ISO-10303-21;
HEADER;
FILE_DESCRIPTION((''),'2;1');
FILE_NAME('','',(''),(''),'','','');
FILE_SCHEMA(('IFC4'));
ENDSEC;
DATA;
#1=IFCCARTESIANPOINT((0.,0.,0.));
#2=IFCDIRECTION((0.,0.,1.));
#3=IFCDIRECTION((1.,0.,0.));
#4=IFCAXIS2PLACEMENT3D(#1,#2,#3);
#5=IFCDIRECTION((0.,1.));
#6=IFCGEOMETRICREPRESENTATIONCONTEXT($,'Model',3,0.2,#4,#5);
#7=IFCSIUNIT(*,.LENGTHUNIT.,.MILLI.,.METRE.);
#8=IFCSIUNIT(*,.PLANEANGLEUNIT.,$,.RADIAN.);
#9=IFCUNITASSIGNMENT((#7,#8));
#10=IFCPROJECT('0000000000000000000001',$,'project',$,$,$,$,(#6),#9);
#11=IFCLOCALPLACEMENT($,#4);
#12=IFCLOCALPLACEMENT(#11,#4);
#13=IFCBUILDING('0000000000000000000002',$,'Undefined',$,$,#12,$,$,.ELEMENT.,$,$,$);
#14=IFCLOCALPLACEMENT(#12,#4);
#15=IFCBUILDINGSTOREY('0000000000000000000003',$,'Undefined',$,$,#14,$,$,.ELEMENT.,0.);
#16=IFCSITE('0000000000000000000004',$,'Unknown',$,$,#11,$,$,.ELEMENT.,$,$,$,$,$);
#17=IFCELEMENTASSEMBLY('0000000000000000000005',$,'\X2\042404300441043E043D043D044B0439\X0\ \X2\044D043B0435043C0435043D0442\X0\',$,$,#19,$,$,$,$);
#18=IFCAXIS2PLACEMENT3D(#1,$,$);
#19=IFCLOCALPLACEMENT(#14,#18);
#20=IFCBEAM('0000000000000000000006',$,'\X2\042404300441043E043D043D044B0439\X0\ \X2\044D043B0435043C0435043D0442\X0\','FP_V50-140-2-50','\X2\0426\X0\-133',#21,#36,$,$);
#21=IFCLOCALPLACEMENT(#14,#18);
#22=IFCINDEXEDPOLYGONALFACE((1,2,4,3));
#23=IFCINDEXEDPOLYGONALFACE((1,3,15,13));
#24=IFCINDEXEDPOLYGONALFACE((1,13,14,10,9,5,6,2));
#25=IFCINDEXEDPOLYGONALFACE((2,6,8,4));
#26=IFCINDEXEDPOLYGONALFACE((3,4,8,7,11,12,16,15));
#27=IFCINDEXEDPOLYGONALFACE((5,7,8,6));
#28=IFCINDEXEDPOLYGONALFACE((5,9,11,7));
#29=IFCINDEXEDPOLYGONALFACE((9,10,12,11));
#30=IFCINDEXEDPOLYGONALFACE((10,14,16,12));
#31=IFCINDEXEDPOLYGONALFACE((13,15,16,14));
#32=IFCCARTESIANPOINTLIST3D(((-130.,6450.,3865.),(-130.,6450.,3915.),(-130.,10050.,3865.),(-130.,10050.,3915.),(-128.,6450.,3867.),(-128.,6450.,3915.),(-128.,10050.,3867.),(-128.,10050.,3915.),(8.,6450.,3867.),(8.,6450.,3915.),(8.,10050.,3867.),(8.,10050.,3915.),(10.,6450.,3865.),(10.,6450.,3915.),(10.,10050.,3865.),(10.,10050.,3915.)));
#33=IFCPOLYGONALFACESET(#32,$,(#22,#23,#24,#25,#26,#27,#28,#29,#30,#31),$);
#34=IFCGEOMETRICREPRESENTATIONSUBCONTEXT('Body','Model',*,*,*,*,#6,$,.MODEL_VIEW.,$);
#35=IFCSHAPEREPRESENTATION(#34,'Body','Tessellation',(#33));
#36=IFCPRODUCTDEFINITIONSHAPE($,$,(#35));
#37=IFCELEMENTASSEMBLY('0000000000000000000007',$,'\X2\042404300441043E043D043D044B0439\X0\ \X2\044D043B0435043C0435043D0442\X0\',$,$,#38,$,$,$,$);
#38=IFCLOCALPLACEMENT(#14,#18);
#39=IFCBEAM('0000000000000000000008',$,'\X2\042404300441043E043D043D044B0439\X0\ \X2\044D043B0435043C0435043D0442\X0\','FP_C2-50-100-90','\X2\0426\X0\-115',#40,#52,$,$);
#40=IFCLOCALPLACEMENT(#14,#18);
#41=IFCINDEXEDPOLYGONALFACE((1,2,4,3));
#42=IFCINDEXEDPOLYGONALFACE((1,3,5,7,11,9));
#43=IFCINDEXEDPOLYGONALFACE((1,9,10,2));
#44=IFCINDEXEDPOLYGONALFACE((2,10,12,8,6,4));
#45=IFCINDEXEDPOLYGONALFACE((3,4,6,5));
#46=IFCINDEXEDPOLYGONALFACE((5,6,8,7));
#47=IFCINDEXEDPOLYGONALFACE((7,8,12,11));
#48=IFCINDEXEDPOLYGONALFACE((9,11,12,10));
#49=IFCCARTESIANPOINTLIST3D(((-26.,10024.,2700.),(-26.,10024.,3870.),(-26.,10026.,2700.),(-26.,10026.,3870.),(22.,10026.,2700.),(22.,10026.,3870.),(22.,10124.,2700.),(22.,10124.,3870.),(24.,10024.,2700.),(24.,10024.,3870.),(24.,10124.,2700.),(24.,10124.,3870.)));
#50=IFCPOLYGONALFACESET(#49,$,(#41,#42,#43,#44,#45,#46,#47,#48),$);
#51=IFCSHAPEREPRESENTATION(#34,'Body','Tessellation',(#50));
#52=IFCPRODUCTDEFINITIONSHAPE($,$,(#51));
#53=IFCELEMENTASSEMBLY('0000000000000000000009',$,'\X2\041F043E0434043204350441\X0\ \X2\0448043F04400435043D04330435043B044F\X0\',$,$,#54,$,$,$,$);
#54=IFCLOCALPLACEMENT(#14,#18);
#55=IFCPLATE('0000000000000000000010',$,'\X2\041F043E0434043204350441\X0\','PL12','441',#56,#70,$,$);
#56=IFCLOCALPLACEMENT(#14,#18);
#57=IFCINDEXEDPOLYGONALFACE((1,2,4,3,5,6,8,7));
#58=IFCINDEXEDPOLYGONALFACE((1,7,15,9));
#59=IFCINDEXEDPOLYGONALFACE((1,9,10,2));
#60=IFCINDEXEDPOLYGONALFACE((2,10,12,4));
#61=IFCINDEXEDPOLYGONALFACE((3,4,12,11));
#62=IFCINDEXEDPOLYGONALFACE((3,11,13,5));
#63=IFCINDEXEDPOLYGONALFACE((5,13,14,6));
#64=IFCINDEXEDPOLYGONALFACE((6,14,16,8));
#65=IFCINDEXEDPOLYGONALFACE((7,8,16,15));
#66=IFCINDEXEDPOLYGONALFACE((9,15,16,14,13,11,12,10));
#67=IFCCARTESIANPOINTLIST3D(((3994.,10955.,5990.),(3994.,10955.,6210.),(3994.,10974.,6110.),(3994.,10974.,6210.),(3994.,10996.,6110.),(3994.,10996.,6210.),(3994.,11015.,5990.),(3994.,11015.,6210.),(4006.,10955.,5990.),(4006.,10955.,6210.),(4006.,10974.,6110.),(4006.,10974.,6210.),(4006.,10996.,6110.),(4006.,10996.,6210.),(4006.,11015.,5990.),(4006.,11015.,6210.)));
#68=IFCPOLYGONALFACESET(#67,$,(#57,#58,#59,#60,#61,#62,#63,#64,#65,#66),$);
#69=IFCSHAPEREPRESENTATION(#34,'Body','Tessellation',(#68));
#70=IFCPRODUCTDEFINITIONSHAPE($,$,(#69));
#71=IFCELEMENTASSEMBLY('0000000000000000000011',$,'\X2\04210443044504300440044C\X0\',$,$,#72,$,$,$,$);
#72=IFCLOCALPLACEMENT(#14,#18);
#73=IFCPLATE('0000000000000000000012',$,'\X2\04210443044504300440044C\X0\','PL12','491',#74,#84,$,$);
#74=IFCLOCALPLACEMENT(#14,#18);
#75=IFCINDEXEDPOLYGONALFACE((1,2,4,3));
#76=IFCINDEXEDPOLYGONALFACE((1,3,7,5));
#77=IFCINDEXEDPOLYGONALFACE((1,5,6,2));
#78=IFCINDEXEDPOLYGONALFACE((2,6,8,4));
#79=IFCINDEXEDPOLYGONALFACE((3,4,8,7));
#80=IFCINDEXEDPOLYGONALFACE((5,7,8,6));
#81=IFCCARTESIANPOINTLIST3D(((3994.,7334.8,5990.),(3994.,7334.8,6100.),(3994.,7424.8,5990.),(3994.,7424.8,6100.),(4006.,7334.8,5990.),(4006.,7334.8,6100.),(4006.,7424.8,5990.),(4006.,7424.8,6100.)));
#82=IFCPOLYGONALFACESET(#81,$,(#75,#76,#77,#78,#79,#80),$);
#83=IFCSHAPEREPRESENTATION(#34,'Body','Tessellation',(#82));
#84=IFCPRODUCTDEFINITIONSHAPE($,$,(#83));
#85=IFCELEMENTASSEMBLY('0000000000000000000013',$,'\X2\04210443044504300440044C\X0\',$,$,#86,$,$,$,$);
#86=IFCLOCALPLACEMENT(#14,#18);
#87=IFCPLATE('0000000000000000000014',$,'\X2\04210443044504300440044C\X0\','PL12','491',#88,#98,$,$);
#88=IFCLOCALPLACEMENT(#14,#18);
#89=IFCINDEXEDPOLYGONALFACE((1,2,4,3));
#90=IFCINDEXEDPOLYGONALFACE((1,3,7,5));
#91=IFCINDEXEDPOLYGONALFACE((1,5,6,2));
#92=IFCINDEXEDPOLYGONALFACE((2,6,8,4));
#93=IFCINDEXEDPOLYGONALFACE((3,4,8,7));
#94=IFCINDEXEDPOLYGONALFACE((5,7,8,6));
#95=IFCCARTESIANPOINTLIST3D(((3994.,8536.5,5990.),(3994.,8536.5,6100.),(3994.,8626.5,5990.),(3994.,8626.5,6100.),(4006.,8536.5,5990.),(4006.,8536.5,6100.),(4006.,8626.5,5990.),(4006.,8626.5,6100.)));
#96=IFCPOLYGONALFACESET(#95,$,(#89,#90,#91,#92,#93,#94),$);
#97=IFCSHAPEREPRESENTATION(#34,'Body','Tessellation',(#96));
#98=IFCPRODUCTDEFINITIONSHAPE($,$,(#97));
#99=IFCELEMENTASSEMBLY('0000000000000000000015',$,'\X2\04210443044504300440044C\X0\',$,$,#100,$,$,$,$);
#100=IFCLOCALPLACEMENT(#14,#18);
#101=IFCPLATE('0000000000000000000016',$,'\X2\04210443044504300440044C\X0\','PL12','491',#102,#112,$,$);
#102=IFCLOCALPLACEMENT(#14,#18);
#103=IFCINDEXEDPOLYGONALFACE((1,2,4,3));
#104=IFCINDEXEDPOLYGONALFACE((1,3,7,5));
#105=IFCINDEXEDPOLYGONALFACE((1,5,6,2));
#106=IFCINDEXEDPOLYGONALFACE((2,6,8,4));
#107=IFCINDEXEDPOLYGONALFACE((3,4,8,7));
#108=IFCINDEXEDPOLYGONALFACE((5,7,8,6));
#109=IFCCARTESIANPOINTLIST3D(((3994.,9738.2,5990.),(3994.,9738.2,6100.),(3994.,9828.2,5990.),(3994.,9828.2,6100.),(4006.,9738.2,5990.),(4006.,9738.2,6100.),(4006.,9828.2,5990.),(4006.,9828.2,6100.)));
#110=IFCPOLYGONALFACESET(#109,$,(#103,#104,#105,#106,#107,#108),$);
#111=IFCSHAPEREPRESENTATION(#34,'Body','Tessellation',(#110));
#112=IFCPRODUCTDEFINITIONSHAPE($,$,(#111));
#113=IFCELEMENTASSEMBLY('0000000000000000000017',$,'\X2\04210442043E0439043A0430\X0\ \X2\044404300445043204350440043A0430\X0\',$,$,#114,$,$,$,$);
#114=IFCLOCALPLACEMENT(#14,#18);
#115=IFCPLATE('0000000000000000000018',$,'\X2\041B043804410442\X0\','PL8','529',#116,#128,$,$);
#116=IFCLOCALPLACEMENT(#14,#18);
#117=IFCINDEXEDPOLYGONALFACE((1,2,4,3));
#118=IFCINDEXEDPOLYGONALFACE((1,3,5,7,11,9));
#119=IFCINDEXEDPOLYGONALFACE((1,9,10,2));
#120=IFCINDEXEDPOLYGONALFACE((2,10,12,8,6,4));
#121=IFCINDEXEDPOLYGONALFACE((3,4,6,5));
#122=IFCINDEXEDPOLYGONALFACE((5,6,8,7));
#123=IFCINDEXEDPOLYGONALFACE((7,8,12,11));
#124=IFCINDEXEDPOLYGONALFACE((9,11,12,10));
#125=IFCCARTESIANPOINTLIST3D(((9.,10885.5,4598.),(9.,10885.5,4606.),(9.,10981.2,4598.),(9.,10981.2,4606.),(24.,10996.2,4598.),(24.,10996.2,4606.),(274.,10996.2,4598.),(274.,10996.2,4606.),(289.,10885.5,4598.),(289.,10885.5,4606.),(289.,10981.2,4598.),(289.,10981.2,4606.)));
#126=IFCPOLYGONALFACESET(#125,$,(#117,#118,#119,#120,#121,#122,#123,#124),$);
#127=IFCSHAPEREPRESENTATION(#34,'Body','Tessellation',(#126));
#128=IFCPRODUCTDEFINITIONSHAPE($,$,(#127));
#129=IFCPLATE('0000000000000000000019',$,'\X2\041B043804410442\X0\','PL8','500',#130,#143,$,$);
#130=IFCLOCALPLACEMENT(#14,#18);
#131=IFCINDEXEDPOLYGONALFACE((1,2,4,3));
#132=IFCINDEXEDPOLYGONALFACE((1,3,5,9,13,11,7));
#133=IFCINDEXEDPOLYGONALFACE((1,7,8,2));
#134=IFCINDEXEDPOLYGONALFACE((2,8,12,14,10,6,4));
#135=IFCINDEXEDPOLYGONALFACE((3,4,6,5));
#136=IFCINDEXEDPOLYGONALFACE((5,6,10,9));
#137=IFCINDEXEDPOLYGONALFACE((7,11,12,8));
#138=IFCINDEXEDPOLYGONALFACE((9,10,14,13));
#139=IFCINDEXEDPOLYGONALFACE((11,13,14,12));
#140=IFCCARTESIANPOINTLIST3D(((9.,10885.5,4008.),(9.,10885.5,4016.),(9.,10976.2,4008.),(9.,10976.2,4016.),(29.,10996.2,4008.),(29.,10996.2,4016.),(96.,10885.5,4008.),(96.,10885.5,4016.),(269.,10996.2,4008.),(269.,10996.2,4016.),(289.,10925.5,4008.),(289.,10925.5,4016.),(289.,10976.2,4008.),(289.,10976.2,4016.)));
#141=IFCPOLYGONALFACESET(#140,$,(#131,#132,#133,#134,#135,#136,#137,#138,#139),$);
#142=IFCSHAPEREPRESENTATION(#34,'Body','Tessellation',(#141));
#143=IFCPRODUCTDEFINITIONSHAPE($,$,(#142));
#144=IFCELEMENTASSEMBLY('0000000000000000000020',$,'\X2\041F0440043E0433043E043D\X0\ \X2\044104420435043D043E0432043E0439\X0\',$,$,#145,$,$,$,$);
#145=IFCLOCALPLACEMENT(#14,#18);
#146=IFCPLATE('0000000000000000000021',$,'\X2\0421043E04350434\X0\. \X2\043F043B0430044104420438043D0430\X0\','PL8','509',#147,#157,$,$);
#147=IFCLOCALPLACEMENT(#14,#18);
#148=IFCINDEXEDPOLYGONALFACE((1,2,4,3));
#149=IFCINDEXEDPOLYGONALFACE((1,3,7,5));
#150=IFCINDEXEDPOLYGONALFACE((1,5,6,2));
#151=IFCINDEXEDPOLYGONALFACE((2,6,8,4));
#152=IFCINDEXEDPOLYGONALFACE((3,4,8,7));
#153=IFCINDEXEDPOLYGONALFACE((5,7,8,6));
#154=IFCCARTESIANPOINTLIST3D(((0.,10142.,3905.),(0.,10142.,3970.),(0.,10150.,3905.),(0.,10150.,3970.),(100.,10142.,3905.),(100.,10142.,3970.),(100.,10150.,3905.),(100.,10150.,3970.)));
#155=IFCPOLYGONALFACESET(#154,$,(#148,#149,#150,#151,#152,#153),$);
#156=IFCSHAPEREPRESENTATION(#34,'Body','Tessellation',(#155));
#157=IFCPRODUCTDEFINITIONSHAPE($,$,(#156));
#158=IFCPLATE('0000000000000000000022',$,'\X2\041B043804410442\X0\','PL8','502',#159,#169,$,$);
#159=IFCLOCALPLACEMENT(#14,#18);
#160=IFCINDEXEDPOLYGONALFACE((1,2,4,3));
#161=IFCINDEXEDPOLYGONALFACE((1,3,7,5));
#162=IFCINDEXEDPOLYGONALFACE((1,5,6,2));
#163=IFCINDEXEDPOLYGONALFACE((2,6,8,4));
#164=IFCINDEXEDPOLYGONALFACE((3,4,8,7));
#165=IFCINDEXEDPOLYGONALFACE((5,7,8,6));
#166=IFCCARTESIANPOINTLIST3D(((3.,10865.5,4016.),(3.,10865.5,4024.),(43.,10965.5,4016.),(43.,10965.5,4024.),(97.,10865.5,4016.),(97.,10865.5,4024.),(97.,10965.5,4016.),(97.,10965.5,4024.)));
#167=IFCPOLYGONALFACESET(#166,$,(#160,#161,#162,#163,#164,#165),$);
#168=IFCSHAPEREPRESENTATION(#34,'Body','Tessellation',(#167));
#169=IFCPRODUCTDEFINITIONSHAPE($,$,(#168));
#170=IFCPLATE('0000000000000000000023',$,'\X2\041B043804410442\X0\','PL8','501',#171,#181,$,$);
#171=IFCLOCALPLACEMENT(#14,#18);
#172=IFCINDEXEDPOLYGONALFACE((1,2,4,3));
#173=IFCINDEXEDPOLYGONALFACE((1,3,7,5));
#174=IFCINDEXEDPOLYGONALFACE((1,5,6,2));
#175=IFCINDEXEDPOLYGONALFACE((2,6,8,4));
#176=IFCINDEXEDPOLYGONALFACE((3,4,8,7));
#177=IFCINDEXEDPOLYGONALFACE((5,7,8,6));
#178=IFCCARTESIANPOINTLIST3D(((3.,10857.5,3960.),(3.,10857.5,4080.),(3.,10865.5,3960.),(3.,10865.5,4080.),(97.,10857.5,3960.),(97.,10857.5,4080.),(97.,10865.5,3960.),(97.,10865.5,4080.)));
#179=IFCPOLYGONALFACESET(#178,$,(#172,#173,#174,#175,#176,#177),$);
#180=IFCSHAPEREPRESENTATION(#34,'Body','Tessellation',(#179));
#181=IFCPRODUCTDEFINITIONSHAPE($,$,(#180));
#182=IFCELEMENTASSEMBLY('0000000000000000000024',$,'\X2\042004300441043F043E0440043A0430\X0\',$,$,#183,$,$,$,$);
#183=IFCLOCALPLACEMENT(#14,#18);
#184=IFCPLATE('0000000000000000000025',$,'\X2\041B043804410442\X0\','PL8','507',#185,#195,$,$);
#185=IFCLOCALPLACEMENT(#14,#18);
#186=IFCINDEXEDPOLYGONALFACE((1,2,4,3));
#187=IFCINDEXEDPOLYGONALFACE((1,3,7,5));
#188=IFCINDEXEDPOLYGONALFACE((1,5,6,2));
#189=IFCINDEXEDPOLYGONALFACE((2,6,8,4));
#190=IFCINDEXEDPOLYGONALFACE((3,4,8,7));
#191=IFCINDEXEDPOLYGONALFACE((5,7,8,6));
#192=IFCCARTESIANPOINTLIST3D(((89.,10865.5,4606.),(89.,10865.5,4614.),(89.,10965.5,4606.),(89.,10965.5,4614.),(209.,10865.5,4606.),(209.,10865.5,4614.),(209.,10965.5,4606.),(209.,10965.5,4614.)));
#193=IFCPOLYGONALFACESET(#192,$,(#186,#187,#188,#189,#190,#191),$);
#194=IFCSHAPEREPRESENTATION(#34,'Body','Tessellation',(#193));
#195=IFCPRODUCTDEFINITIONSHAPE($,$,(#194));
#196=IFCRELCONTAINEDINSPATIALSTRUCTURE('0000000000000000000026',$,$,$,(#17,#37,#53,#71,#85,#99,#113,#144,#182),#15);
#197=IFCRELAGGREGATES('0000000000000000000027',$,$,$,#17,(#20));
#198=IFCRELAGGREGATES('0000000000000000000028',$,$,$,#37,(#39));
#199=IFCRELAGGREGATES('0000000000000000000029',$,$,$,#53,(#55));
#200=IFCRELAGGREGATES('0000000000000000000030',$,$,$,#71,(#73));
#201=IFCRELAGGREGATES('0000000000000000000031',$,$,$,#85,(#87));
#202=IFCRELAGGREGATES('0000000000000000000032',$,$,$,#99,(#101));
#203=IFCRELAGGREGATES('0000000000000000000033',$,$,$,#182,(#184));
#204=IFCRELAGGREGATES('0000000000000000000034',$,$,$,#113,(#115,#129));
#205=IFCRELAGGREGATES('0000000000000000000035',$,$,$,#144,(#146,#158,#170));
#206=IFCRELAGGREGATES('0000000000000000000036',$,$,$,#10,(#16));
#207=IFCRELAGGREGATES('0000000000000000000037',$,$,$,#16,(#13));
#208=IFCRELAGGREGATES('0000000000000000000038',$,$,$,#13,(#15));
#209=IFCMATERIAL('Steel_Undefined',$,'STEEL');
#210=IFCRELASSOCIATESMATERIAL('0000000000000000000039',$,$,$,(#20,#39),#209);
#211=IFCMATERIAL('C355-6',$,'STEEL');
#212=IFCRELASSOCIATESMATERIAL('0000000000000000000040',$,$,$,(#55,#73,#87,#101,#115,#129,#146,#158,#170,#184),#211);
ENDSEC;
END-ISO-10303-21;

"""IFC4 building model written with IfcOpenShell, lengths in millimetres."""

from ifc_helpers import new_model, si_unit, direction, frame, origin_with_axes, place, context, subcontext, project, spatial, line, indexed_curve, outline, extrude, material, element, aggregate, save


model = new_model("IFC4")

# Units and contexts
model_context = context("Model", 3, precision=0.2, world=origin_with_axes(), true_north=direction((0.0, 1.0)))
body_context = subcontext(model_context, "Body", "Model", "MODEL_VIEW")
ifc_project = project(units=[si_unit("LENGTHUNIT", "METRE", prefix="MILLI"), si_unit("PLANEANGLEUNIT", "RADIAN")], contexts=[model_context])

# Site, building, storey
site_placement = place(None, origin_with_axes())
site = spatial("IfcSite", under=ifc_project, at=site_placement, Name="Unknown", CompositionType="ELEMENT")
building_placement = place(site_placement, origin_with_axes())
building = spatial("IfcBuilding", under=site, at=building_placement, Name="Undefined", CompositionType="ELEMENT")
storey_placement = place(building_placement, origin_with_axes())
storey = spatial("IfcBuildingStorey", under=building, at=storey_placement, Name="Undefined", CompositionType="ELEMENT", Elevation=0.0)

# Element assemblies, beams
assembly_1_placement = place(storey_placement, frame((-60.0, 10050.0, 3890.0), z_axis=(1.0, 0.0, 0.0), x_axis=(0.0, -1.0, 0.0)))
assembly_1 = element("IfcElementAssembly", 1, at=assembly_1_placement, inside=storey, Name="Фасонный элемент")
ifc_material_1 = material(Name="Steel_Undefined", Category="STEEL")
beam_1_placement = place(assembly_1_placement, origin_with_axes())
beam_1 = element("IfcBeam", 2, at=beam_1_placement, material=ifc_material_1, Name="Фасонный элемент", Description="FP_V50-140-2-50", ObjectType="Ц-133", context=body_context, shape_type="SolidModel", body=[
    extrude(outline(indexed_curve([(-70.0, -25.0), (-68.0, -25.0), (-68.0, 23.0), (68.0, 23.0), (68.0, -25.0), (70.0, -25.0), (70.0, 25.0), (-70.0, 25.0)], segments=[line(1, 2, 3, 4, 5, 6, 7, 8, 1)])), frame((0.0, 0.0, 0.0), z_axis=(-1.0, 0.0, 0.0), x_axis=(0.0, 0.0, 1.0)), (0.0, 0.0, -1.0), 3600.0),
])
aggregate(assembly_1, [beam_1])
assembly_2_placement = place(storey_placement, frame((-1.0, 10025.0, 3870.0), z_axis=(1.0, 0.0, 0.0), x_axis=(0.0, 0.0, -1.0)))
assembly_2 = element("IfcElementAssembly", 3, at=assembly_2_placement, inside=storey, Name="Фасонный элемент")
beam_2_placement = place(assembly_2_placement, origin_with_axes())
beam_2 = element("IfcBeam", 4, at=beam_2_placement, material=ifc_material_1, Name="Фасонный элемент", Description="FP_C2-50-100-90", ObjectType="Ц-115", context=body_context, shape_type="SolidModel", body=[
    extrude(outline(indexed_curve([(-25.0, -1.0), (25.0, -1.0), (25.0, 99.0), (23.0, 99.0), (23.0, 1.0), (-25.0, 1.0)], segments=[line(1, 2, 3, 4, 5, 6, 1)])), frame((0.0, 0.0, 0.0), z_axis=(-1.0, 0.0, 0.0), x_axis=(0.0, 0.0, 1.0)), (0.0, 0.0, -1.0), 1170.0),
])
aggregate(assembly_2, [beam_2])

# Element assemblies, plates
assembly_3_placement = place(storey_placement, frame((4000.0, 10985.0, 8155.1), z_axis=(0.0, -1.0, 0.0), x_axis=(0.0, 0.0, -1.0)))
assembly_3 = element("IfcElementAssembly", 5, at=assembly_3_placement, inside=storey, Name="Подвес шпренгеля")
ifc_material_2 = material(Name="C355-6", Category="STEEL")
plate_1_placement = place(assembly_3_placement, frame((2165.1, 0.0, 30.0), z_axis=(0.0, 1.0, 0.0), x_axis=(0.0, 0.0, -1.0)))
plate_1 = element("IfcPlate", 6, at=plate_1_placement, material=ifc_material_2, Name="Подвес", Description="PL12", ObjectType="441", context=body_context, shape_type="SolidModel", body=[
    extrude(outline(indexed_curve([(0.0, 0.0), (60.0, 0.0), (60.0, 220.0), (41.0, 220.0), (41.0, 120.0), (19.0, 120.0), (19.0, 220.0), (0.0, 220.0)], segments=[line(1, 2, 3, 4, 5, 6, 7, 8, 1)])), frame((0.0, 0.0, 6.0), z_axis=(0.0, 0.0, 1.0), x_axis=(1.0, 0.0, 0.0)), (0.0, 0.0, -1.0), 12.0),
])
aggregate(assembly_3, [plate_1])
assembly_4_placement = place(storey_placement, frame((4000.0, 7334.8, 6100.0), z_axis=(-1.0, 0.0, 0.0), x_axis=(0.0, 1.0, 0.0)))
assembly_4 = element("IfcElementAssembly", 7, at=assembly_4_placement, inside=storey, Name="Сухарь")
plate_2_placement = place(assembly_4_placement, origin_with_axes())
plate_2 = element("IfcPlate", 8, at=plate_2_placement, material=ifc_material_2, Name="Сухарь", Description="PL12", ObjectType="491", context=body_context, shape_type="SolidModel", body=[
    extrude(outline(indexed_curve([(0.0, 0.0), (90.0, 0.0), (90.0, 110.0), (0.0, 110.0)], segments=[line(1, 2, 3, 4, 1)])), frame((0.0, 0.0, 6.0), z_axis=(0.0, 0.0, 1.0), x_axis=(1.0, 0.0, 0.0)), (0.0, 0.0, -1.0), 12.0),
])
aggregate(assembly_4, [plate_2])
assembly_5_placement = place(storey_placement, frame((4000.0, 8536.5, 6100.0), z_axis=(-1.0, 0.0, 0.0), x_axis=(0.0, 1.0, 0.0)))
assembly_5 = element("IfcElementAssembly", 9, at=assembly_5_placement, inside=storey, Name="Сухарь")
plate_3_placement = place(assembly_5_placement, origin_with_axes())
plate_3 = element("IfcPlate", 10, at=plate_3_placement, material=ifc_material_2, Name="Сухарь", Description="PL12", ObjectType="491", context=body_context, shape_type="SolidModel", body=[
    extrude(outline(indexed_curve([(0.0, 0.0), (90.0, 0.0), (90.0, 110.0), (0.0, 110.0)], segments=[line(1, 2, 3, 4, 1)])), frame((0.0, 0.0, 6.0), z_axis=(0.0, 0.0, 1.0), x_axis=(1.0, 0.0, 0.0)), (0.0, 0.0, -1.0), 12.0),
])
aggregate(assembly_5, [plate_3])
assembly_6_placement = place(storey_placement, frame((4000.0, 9738.2, 6100.0), z_axis=(-1.0, 0.0, 0.0), x_axis=(0.0, 1.0, 0.0)))
assembly_6 = element("IfcElementAssembly", 11, at=assembly_6_placement, inside=storey, Name="Сухарь")
plate_4_placement = place(assembly_6_placement, origin_with_axes())
plate_4 = element("IfcPlate", 12, at=plate_4_placement, material=ifc_material_2, Name="Сухарь", Description="PL12", ObjectType="491", context=body_context, shape_type="SolidModel", body=[
    extrude(outline(indexed_curve([(0.0, 0.0), (90.0, 0.0), (90.0, 110.0), (0.0, 110.0)], segments=[line(1, 2, 3, 4, 1)])), frame((0.0, 0.0, 6.0), z_axis=(0.0, 0.0, 1.0), x_axis=(1.0, 0.0, 0.0)), (0.0, 0.0, -1.0), 12.0),
])
aggregate(assembly_6, [plate_4])

# Element assemblies, plates
assembly_7_placement = place(storey_placement, frame((149.0, 11000.0, -200.0), z_axis=(0.0, -1.0, 0.0), x_axis=(0.0, 0.0, 1.0)))
assembly_7 = element("IfcElementAssembly", 13, at=assembly_7_placement, inside=storey, Name="Стойка фахверка")
plate_5_placement = place(assembly_7_placement, frame((4802.0, 140.0, 114.5), z_axis=(-1.0, 0.0, 0.0), x_axis=(0.0, 0.0, -1.0)))
plate_5 = element("IfcPlate", 14, at=plate_5_placement, material=ifc_material_2, Name="Лист", Description="PL8", ObjectType="529", context=body_context, shape_type="SolidModel", body=[
    extrude(outline(indexed_curve([(0.0, 0.0), (95.8, 0.0), (110.8, 15.0), (110.8, 265.0), (95.8, 280.0), (0.0, 280.0)], segments=[line(1, 2, 3, 4, 5, 6, 1)])), frame((0.0, 0.0, 4.0), z_axis=(0.0, 0.0, 1.0), x_axis=(1.0, 0.0, 0.0)), (0.0, 0.0, -1.0), 8.0),
])
plate_6_placement = place(assembly_7_placement, frame((4212.0, 140.0, 3.8), z_axis=(1.0, 0.0, 0.0), x_axis=(0.0, 0.0, 1.0)))
plate_6 = element("IfcPlate", 15, at=plate_6_placement, material=ifc_material_2, Name="Лист", Description="PL8", ObjectType="500", context=body_context, shape_type="SolidModel", body=[
    extrude(outline(indexed_curve([(0.0, 20.0), (20.0, 0.0), (110.8, 0.0), (110.8, 87.0), (70.8, 280.0), (20.0, 280.0), (0.0, 260.0)], segments=[line(1, 2, 3, 4, 5, 6, 7, 1)])), frame((0.0, 0.0, 4.0), z_axis=(0.0, 0.0, 1.0), x_axis=(1.0, 0.0, 0.0)), (0.0, 0.0, -1.0), 8.0),
])
assembly_8_placement = place(storey_placement, frame((50.0, 11000.0, 4020.0), z_axis=(0.0, 0.0, -1.0), x_axis=(0.0, -1.0, 0.0)))
assembly_8 = element("IfcElementAssembly", 16, at=assembly_8_placement, inside=storey, Name="Прогон стеновой")
plate_7_placement = place(assembly_8_placement, frame((854.0, -50.0, 50.0), z_axis=(-1.0, 0.0, 0.0), x_axis=(0.0, 0.0, 1.0)))
plate_7 = element("IfcPlate", 17, at=plate_7_placement, material=ifc_material_2, Name="Соед. пластина", Description="PL8", ObjectType="509", context=body_context, shape_type="SolidModel", body=[
    extrude(outline(indexed_curve([(0.0, 0.0), (65.0, 0.0), (65.0, 100.0), (0.0, 100.0)], segments=[line(1, 2, 3, 4, 1)])), frame((0.0, 0.0, 4.0), z_axis=(0.0, 0.0, 1.0), x_axis=(1.0, 0.0, 0.0)), (0.0, 0.0, -1.0), 8.0),
])
plate_8_placement = place(assembly_8_placement, frame((34.5, 47.0, 0.0), z_axis=(0.0, 0.0, 1.0), x_axis=(0.0, -1.0, 0.0)))
plate_8 = element("IfcPlate", 18, at=plate_8_placement, material=ifc_material_2, Name="Лист", Description="PL8", ObjectType="502", context=body_context, shape_type="SolidModel", body=[
    extrude(outline(indexed_curve([(0.0, 100.0), (40.0, 0.0), (94.0, 0.0), (94.0, 100.0), (0.0, 100.0)], segments=[line(1, 2, 3, 4, 5, 1)])), frame((0.0, 0.0, 4.0), z_axis=(0.0, 0.0, 1.0), x_axis=(1.0, 0.0, 0.0)), (0.0, 0.0, -1.0), 8.0),
])
plate_9_placement = place(assembly_8_placement, frame((138.5, 47.0, -60.0), z_axis=(-1.0, 0.0, 0.0), x_axis=(0.0, -1.0, 0.0)))
plate_9 = element("IfcPlate", 19, at=plate_9_placement, material=ifc_material_2, Name="Лист", Description="PL8", ObjectType="501", context=body_context, shape_type="SolidModel", body=[
    extrude(outline(indexed_curve([(0.0, 0.0), (94.0, 0.0), (94.0, 120.0), (0.0, 120.0)], segments=[line(1, 2, 3, 4, 1)])), frame((0.0, 0.0, 4.0), z_axis=(0.0, 0.0, 1.0), x_axis=(1.0, 0.0, 0.0)), (0.0, 0.0, -1.0), 8.0),
])
assembly_9_placement = place(storey_placement, frame((149.0, 11000.0, 4610.0), z_axis=(0.0, 0.0, -1.0), x_axis=(0.0, -1.0, 0.0)))
assembly_9 = element("IfcElementAssembly", 20, at=assembly_9_placement, inside=storey, Name="Распорка")
plate_10_placement = place(assembly_9_placement, frame((34.5, 60.0, 0.0), z_axis=(0.0, 0.0, 1.0), x_axis=(0.0, -1.0, 0.0)))
plate_10 = element("IfcPlate", 21, at=plate_10_placement, material=ifc_material_2, Name="Лист", Description="PL8", ObjectType="507", context=body_context, shape_type="SolidModel", body=[
    extrude(outline(indexed_curve([(0.0, 0.0), (120.0, 0.0), (120.0, 100.0), (0.0, 100.0)], segments=[line(1, 2, 3, 4, 1)])), frame((0.0, 0.0, 4.0), z_axis=(0.0, 0.0, 1.0), x_axis=(1.0, 0.0, 0.0)), (0.0, 0.0, -1.0), 8.0),
])
aggregate(assembly_9, [plate_10])

aggregate(assembly_7, [plate_5, plate_6])

aggregate(assembly_8, [plate_7, plate_8, plate_9])

save(model, "model.ifc")
